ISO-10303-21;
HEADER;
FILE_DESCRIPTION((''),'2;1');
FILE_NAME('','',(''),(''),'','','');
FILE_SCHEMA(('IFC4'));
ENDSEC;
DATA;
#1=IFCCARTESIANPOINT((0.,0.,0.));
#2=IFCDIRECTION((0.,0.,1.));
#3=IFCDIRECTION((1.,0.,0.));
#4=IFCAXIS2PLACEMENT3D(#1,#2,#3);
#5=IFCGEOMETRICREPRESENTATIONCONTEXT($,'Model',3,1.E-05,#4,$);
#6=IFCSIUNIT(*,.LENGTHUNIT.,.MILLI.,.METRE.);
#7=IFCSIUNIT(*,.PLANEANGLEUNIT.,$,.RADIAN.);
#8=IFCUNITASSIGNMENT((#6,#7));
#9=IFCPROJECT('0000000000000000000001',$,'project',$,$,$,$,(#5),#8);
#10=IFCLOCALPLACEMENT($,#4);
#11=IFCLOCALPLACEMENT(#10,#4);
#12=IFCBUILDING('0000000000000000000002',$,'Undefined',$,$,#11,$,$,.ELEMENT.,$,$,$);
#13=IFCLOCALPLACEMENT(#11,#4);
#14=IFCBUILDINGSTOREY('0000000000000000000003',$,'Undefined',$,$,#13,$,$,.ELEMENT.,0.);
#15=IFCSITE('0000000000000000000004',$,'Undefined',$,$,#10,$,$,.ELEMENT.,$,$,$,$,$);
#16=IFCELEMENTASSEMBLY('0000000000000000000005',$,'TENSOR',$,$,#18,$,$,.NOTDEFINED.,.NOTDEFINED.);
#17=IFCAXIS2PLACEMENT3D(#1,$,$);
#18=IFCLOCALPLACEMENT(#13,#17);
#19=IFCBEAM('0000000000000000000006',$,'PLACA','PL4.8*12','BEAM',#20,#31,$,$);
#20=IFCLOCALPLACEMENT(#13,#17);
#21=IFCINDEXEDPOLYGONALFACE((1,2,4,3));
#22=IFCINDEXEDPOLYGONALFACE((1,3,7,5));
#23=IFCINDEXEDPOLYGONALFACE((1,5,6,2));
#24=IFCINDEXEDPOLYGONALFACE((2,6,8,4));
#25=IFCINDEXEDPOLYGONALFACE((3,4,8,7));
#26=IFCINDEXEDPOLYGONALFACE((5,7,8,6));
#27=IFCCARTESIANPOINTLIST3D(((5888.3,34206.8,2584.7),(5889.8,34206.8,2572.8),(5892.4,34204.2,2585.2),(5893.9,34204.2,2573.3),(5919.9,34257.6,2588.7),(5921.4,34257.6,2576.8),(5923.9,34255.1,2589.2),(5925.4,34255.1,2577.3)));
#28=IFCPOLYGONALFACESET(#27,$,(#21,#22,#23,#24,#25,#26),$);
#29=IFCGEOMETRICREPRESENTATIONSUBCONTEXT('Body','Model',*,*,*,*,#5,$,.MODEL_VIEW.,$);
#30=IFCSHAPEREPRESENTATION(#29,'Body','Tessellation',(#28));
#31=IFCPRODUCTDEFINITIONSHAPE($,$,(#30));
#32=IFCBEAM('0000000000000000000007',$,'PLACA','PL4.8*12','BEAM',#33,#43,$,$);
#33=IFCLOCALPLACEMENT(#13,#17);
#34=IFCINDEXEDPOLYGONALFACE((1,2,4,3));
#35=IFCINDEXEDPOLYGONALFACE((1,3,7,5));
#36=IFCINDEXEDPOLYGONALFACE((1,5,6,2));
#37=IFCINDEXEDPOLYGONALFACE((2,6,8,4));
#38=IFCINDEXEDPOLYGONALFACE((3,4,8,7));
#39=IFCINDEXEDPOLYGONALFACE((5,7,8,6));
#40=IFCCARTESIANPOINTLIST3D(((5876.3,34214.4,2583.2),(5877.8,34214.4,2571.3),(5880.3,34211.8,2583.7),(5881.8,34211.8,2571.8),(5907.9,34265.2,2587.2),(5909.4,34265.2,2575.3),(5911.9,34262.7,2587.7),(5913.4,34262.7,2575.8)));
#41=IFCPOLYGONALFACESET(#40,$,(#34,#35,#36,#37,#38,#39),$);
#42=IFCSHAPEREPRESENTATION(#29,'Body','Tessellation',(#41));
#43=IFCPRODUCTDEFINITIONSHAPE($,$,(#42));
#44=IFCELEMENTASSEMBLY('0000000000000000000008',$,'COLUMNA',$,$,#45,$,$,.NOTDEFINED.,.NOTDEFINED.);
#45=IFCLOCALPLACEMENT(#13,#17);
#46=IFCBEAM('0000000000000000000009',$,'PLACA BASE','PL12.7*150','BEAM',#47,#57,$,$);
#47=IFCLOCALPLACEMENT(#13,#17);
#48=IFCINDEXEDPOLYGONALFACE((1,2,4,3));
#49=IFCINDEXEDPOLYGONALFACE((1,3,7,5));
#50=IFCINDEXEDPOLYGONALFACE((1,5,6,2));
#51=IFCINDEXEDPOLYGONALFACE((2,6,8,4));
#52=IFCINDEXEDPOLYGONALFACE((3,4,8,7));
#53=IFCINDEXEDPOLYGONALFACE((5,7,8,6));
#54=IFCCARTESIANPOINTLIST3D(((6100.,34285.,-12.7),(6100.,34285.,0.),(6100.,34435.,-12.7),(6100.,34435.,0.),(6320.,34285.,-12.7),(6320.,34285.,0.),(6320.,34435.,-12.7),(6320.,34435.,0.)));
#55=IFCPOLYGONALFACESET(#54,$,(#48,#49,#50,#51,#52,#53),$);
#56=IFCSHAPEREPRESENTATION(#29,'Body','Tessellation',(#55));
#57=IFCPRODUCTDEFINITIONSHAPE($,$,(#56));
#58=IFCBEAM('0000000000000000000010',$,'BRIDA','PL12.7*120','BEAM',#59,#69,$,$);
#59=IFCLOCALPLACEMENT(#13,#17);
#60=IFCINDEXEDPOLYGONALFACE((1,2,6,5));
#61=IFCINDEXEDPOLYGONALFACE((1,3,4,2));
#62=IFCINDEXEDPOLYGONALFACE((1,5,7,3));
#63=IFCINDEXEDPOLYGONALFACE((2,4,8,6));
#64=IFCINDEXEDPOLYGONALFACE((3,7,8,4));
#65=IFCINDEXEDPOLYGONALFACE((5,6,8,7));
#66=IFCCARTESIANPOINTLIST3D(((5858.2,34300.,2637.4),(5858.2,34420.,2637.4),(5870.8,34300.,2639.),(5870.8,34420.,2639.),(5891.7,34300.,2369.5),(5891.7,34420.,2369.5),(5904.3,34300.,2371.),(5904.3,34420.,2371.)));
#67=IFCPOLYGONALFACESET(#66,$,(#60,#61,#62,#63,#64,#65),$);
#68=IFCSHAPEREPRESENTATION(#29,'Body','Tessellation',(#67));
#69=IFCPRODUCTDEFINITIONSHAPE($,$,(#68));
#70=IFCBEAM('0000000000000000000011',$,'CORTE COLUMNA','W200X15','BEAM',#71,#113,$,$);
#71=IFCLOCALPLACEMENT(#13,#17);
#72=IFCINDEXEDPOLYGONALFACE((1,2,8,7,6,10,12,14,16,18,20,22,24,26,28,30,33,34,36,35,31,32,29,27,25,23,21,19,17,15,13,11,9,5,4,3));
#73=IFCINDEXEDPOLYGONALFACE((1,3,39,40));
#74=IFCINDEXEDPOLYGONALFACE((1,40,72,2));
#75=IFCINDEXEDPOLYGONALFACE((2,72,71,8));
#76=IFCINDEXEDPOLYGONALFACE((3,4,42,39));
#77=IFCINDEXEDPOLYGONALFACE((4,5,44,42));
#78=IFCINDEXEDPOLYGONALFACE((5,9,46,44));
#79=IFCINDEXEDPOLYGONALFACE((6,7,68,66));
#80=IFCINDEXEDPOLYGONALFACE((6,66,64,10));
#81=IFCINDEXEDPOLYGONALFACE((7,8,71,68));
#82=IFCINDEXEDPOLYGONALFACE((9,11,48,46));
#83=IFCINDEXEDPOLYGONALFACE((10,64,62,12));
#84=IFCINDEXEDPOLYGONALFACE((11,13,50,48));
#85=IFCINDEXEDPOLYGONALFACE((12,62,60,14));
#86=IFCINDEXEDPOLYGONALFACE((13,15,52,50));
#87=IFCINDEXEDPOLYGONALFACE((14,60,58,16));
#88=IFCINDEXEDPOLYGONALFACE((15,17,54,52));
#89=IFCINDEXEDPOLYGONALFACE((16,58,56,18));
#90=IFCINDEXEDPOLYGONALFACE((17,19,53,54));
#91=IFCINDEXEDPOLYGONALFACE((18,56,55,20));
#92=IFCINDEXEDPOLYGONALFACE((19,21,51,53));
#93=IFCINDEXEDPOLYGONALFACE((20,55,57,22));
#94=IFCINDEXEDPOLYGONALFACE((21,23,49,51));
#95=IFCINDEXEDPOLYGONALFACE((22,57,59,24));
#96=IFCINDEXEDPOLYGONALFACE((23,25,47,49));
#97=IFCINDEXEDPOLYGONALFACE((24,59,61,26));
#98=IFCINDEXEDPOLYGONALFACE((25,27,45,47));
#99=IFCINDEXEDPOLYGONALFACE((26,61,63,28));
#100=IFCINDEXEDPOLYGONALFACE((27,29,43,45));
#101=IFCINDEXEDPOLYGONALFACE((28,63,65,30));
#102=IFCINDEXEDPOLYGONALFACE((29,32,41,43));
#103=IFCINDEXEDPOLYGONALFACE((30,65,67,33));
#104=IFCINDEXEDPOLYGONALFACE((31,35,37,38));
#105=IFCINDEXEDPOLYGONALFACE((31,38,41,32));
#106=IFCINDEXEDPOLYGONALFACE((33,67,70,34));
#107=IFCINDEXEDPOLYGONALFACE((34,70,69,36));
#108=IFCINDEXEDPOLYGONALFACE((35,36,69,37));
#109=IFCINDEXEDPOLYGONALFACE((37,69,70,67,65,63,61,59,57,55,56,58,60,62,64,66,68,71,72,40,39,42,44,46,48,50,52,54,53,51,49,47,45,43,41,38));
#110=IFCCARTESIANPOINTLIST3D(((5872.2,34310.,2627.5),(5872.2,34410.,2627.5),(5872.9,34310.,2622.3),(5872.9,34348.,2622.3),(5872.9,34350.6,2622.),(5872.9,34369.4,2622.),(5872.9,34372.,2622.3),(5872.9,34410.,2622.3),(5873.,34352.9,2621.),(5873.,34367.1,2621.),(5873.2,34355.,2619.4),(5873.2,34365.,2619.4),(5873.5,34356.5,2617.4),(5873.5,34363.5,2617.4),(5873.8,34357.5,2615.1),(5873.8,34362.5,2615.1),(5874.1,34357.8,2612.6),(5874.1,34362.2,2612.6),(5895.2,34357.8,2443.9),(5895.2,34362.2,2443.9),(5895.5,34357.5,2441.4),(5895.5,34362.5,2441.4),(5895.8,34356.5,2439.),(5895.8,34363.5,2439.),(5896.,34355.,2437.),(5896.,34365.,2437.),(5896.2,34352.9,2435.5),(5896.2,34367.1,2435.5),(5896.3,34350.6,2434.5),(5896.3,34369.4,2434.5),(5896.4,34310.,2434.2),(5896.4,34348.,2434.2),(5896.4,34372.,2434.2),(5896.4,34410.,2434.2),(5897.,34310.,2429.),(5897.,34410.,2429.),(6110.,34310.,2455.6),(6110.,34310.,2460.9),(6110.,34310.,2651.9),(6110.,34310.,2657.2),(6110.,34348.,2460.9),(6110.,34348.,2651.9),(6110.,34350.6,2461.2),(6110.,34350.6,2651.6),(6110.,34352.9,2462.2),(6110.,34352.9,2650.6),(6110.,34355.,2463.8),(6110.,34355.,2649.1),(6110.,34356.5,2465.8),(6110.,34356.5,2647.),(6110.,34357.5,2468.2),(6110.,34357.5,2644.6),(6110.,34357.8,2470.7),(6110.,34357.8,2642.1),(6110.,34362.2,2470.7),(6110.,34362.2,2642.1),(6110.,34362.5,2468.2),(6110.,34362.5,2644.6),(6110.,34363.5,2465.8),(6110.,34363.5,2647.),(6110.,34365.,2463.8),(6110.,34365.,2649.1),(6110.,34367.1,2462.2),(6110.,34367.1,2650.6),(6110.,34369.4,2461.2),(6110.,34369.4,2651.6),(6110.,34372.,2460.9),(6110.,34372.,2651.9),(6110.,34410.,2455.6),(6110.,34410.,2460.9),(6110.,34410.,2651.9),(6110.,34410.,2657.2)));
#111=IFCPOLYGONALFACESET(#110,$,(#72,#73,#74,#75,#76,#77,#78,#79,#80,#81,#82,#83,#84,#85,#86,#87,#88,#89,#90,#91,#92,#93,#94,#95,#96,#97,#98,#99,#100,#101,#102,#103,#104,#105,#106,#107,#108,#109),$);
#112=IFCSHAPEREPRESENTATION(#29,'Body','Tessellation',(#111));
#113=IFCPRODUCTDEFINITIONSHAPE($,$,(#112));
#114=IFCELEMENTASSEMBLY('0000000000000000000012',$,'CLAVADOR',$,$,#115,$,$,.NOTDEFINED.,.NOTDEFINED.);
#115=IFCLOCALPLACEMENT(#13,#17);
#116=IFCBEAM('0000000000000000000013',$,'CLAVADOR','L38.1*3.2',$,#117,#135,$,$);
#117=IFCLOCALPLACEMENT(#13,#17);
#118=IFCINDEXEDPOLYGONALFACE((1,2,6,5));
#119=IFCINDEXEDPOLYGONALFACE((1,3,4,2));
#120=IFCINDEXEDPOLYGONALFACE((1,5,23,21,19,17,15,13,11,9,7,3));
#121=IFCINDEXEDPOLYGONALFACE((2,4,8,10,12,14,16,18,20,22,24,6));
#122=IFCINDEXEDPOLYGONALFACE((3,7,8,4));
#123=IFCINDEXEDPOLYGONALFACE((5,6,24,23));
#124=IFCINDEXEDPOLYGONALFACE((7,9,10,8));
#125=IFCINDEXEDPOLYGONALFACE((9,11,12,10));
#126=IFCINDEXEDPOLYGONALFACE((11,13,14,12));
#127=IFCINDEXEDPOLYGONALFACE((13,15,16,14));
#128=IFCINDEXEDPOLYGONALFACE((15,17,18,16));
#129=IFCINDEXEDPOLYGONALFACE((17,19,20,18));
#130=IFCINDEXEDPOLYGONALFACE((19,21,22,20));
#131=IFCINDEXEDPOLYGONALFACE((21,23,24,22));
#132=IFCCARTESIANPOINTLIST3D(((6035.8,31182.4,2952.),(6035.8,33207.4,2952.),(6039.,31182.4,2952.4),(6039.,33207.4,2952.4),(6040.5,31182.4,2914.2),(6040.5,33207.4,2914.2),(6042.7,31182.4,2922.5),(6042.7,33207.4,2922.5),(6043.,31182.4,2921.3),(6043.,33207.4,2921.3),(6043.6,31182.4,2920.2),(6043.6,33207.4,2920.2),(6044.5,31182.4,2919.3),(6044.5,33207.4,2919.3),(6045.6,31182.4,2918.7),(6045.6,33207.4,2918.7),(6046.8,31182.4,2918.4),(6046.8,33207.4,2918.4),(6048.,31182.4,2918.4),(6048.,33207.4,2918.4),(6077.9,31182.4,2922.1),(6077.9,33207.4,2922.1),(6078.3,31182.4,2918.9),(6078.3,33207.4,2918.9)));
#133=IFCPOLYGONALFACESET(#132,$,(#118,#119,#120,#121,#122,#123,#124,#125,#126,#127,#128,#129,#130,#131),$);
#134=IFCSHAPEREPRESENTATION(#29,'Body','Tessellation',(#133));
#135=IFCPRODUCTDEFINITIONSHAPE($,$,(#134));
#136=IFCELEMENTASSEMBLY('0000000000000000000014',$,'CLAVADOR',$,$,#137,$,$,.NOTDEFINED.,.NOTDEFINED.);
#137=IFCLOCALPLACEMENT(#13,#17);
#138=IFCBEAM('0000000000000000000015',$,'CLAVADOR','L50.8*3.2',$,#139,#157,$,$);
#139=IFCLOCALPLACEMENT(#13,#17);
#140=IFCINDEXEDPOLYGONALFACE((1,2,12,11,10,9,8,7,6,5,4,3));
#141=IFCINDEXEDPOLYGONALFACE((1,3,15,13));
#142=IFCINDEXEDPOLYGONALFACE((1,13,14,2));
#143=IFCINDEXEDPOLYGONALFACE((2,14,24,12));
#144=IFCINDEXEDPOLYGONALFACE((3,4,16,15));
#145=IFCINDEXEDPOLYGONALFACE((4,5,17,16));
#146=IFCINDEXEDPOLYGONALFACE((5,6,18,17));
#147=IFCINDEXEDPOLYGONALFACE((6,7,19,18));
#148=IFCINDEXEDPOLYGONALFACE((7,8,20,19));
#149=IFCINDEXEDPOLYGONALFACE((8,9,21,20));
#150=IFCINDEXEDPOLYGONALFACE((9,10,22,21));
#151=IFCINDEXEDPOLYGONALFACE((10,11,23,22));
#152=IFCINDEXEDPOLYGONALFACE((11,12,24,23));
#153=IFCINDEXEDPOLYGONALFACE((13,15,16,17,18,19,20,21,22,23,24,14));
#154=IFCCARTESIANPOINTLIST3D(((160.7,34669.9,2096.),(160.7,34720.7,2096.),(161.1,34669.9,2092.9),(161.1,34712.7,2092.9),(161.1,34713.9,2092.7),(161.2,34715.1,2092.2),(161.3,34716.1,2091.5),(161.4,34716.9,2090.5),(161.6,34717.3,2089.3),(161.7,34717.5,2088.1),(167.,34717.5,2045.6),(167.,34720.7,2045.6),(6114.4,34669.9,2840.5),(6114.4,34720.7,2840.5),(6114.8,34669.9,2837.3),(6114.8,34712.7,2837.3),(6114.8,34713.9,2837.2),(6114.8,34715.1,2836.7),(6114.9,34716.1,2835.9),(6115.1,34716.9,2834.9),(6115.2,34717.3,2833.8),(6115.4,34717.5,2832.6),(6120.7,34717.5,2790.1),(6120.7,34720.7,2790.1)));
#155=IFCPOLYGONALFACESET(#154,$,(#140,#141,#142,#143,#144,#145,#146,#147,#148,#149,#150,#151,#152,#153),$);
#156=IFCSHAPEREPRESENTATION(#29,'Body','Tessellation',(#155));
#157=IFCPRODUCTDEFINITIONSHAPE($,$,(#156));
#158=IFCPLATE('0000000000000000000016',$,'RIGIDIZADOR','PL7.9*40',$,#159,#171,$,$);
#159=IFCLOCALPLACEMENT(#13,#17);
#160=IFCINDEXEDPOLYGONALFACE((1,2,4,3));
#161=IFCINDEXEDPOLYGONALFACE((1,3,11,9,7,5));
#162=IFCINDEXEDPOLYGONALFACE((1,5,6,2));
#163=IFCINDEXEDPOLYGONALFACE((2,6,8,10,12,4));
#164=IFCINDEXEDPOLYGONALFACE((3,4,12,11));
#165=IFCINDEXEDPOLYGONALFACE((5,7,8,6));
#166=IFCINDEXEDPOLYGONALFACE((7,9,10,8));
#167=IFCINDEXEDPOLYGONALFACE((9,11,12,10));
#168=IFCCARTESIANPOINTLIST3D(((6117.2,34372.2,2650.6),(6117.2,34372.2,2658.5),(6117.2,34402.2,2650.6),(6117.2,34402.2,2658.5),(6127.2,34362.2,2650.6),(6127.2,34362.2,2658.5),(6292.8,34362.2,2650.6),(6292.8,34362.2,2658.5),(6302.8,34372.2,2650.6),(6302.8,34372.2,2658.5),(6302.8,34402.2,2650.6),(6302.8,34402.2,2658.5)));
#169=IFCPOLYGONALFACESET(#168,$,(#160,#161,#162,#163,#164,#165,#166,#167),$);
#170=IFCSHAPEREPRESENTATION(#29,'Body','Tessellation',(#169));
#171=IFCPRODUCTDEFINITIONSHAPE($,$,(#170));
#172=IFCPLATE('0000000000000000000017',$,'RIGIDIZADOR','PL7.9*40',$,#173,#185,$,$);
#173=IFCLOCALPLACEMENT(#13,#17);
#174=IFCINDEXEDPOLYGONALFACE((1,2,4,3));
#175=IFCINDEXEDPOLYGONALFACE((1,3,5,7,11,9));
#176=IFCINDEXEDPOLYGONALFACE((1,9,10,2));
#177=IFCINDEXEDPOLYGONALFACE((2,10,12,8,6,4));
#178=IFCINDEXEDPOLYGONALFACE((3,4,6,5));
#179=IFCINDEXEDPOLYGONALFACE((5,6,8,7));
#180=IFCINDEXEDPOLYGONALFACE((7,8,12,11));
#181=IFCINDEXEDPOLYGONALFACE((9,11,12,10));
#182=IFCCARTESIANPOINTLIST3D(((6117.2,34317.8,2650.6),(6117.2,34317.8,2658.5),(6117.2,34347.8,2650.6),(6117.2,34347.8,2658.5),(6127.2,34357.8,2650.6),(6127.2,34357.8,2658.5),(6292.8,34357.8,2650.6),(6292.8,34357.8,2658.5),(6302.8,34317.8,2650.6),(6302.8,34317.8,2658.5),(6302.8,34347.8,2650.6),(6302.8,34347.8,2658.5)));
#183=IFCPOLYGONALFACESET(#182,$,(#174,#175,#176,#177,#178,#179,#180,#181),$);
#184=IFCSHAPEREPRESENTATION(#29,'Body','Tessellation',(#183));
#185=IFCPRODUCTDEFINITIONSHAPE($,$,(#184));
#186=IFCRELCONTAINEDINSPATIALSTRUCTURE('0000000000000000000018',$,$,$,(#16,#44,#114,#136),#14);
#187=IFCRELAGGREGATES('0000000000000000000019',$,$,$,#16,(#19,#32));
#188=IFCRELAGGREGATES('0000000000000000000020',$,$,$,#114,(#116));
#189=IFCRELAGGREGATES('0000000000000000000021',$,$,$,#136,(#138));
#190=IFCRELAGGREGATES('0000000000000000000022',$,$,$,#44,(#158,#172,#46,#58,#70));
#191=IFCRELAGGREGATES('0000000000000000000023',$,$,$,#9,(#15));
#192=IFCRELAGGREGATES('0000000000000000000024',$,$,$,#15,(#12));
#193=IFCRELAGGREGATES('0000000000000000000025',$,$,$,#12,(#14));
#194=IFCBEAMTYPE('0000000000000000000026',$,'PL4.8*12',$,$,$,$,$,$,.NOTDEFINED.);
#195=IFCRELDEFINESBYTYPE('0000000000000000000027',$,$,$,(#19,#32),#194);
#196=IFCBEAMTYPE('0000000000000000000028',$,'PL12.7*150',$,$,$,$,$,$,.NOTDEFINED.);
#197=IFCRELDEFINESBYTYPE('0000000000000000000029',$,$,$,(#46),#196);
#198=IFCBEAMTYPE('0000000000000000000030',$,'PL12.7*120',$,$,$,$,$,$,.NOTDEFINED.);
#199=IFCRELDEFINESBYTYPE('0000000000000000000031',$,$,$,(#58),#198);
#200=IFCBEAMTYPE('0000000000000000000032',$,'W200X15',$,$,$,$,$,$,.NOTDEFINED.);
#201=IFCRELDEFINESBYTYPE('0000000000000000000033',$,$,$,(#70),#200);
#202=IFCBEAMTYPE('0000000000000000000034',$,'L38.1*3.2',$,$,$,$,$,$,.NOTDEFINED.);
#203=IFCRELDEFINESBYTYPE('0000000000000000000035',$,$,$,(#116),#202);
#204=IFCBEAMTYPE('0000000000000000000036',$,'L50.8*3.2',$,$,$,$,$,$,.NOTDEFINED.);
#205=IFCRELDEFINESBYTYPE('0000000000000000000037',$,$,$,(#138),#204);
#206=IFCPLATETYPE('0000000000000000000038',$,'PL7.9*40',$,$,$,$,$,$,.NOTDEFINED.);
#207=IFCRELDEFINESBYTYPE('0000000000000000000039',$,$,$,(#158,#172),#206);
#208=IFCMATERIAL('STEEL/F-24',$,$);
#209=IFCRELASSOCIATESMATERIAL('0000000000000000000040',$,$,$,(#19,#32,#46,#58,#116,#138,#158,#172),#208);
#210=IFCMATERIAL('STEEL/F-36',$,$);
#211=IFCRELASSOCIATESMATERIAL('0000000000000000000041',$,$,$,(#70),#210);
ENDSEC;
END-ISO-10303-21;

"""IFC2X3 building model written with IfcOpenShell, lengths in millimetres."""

from ifc_helpers import new_model, si_unit, frame, origin_with_axes, origin_2d_with_axis, place, context, subcontext, project, spatial, polyline, rectangle, i_section, l_section, outline, extrude, clip, halfspace, material, type_object, element, aggregate, save


model = new_model("IFC2X3")

# Units and contexts
model_context = context("Model", 3, precision=1e-05, world=origin_with_axes())
body_context = subcontext(model_context, "Body", "Model", "MODEL_VIEW")
ifc_project = project(units=[si_unit("LENGTHUNIT", "METRE", prefix="MILLI"), si_unit("PLANEANGLEUNIT", "RADIAN")], contexts=[model_context])

# Site, building, storey
site_placement = place(None, origin_with_axes())
site = spatial("IfcSite", under=ifc_project, at=site_placement, Name="Undefined", CompositionType="ELEMENT")
building_placement = place(site_placement, origin_with_axes())
building = spatial("IfcBuilding", under=site, at=building_placement, Name="Undefined", CompositionType="ELEMENT")
storey_placement = place(building_placement, origin_with_axes())
storey = spatial("IfcBuildingStorey", under=building, at=storey_placement, Name="Undefined", CompositionType="ELEMENT", Elevation=0.0)

# Element assemblies, beams
assembly_1_placement = place(storey_placement, origin_with_axes())
assembly_1 = element("IfcElementAssembly", 1, at=assembly_1_placement, inside=storey, Name="TENSOR", AssemblyPlace="NOTDEFINED", PredefinedType="NOTDEFINED")
ifc_material_1 = material(Name="STEEL/F-24")
beam_type_1 = type_object("IfcBeamType", Name="PL4.8*12", PredefinedType="NOTDEFINED")
beam_1_placement = place(assembly_1_placement, frame((5922.7, 34256.4, 2583.0), z_axis=(0.124075, 0.0, -0.992273), x_axis=(-0.526076, -0.84789, -0.065781)))
beam_1 = element("IfcBeam", 2, at=beam_1_placement, type_object=beam_type_1, material=ifc_material_1, Name="PLACA", Description="PL4.8*12", ObjectType="BEAM", context=body_context, shape_type="SweptSolid", body=[
    extrude(rectangle(XDim=4.8, YDim=12.0, at=origin_2d_with_axis()), frame((60.0, 0.0, 0.0), z_axis=(-1.0, 0.0, 0.0), x_axis=(0.0, -1.0, 0.0)), (0.0, 0.0, 1.0), 60.0),
])
beam_2_placement = place(assembly_1_placement, frame((5910.6, 34264.0, 2581.5), z_axis=(0.124075, 0.0, -0.992273), x_axis=(-0.526076, -0.84789, -0.065781)))
beam_2 = element("IfcBeam", 3, at=beam_2_placement, type_object=beam_type_1, material=ifc_material_1, Name="PLACA", Description="PL4.8*12", ObjectType="BEAM", context=body_context, shape_type="SweptSolid", body=[
    extrude(rectangle(XDim=4.8, YDim=12.0, at=origin_2d_with_axis()), frame((60.0, 0.0, 0.0), z_axis=(-1.0, 0.0, 0.0), x_axis=(0.0, -1.0, 0.0)), (0.0, 0.0, 1.0), 60.0),
])
aggregate(assembly_1, [beam_1, beam_2])
assembly_2_placement = place(storey_placement, origin_with_axes())
assembly_2 = element("IfcElementAssembly", 4, at=assembly_2_placement, inside=storey, Name="COLUMNA", AssemblyPlace="NOTDEFINED", PredefinedType="NOTDEFINED")
beam_type_2 = type_object("IfcBeamType", Name="PL12.7*150", PredefinedType="NOTDEFINED")
beam_3_placement = place(assembly_2_placement, frame((6100.0, 34360.0, -6.4), z_axis=(0.0, -1.0, 0.0), x_axis=(1.0, 0.0, 0.0)))
beam_3 = element("IfcBeam", 5, at=beam_3_placement, type_object=beam_type_2, material=ifc_material_1, Name="PLACA BASE", Description="PL12.7*150", ObjectType="BEAM", context=body_context, shape_type="SweptSolid", body=[
    extrude(rectangle(XDim=12.7, YDim=150.0, at=origin_2d_with_axis()), frame((220.0, 0.0, 0.0), z_axis=(-1.0, 0.0, 0.0), x_axis=(0.0, -1.0, 0.0)), (0.0, 0.0, 1.0), 220.0),
])
beam_type_3 = type_object("IfcBeamType", Name="PL12.7*120", PredefinedType="NOTDEFINED")
beam_4_placement = place(assembly_2_placement, frame((5864.5, 34360.0, 2638.2), z_axis=(0.0, 1.0, 0.0), x_axis=(0.124077, 0.0, -0.992273)))
beam_4 = element("IfcBeam", 6, at=beam_4_placement, type_object=beam_type_3, material=ifc_material_1, Name="BRIDA", Description="PL12.7*120", ObjectType="BEAM", context=body_context, shape_type="SweptSolid", body=[
    extrude(rectangle(XDim=12.7, YDim=120.0, at=origin_2d_with_axis()), frame((270.0, 0.0, 0.0), z_axis=(-1.0, 0.0, 0.0), x_axis=(0.0, -1.0, 0.0)), (0.0, 0.0, 1.0), 270.0),
])
ifc_material_2 = material(Name="STEEL/F-36")
beam_type_4 = type_object("IfcBeamType", Name="W200X15", PredefinedType="NOTDEFINED")
beam_5_placement = place(assembly_2_placement, frame((5872.0, 34360.0, 2526.7), z_axis=(-0.124075, 0.0, 0.992273), x_axis=(0.992273, 0.0, 0.124075)))
beam_5 = element("IfcBeam", 7, at=beam_5_placement, type_object=beam_type_4, material=ifc_material_2, Name="CORTE COLUMNA", Description="W200X15", ObjectType="BEAM", context=body_context, shape_type="Clipping", body=[
    clip(clip(extrude(i_section(OverallWidth=100.0, OverallDepth=200.0, WebThickness=4.3, FlangeThickness=5.2, FilletRadius=9.8, at=origin_2d_with_axis()), frame((277.3, 0.0, 0.0), z_axis=(-1.0, 0.0, 0.0), x_axis=(0.0, -1.0, 0.0)), (0.0, 0.0, 1.0), 302.1), halfspace(frame((239.8, 0.0, 0.0), z_axis=(-0.992273, 0.0, 0.124075), x_axis=(0.0, 1.0, 0.0)), True)), halfspace(frame((12.7, 0.0, 0.0), z_axis=(1.0, 0.0, 0.000002), x_axis=(0.0, -1.0, 0.0)), True)),
])

# Element assemblies, beams
assembly_3_placement = place(storey_placement, origin_with_axes())
assembly_3 = element("IfcElementAssembly", 8, at=assembly_3_placement, inside=storey, Name="CLAVADOR", AssemblyPlace="NOTDEFINED", PredefinedType="NOTDEFINED")
beam_type_5 = type_object("IfcBeamType", Name="L38.1*3.2", PredefinedType="NOTDEFINED")
beam_6_placement = place(assembly_3_placement, frame((6057.0, 33207.4, 2935.5), z_axis=(0.992273, 0.0, 0.124075), x_axis=(0.0, -1.0, 0.0)))
beam_6 = element("IfcBeam", 9, at=beam_6_placement, type_object=beam_type_5, material=ifc_material_1, Name="CLAVADOR", Description="L38.1*3.2", context=body_context, shape_type="SweptSolid", body=[
    extrude(l_section(Depth=38.1, Width=38.1, Thickness=3.2, FilletRadius=4.8, at=origin_2d_with_axis()), frame((2025.0, 0.0, 0.0), z_axis=(-1.0, 0.0, 0.0), x_axis=(0.0, -1.0, 0.0)), (0.0, 0.0, 1.0), 2025.0),
])
aggregate(assembly_3, [beam_6])
assembly_4_placement = place(storey_placement, origin_with_axes())
assembly_4 = element("IfcElementAssembly", 10, at=assembly_4_placement, inside=storey, Name="CLAVADOR", AssemblyPlace="NOTDEFINED", PredefinedType="NOTDEFINED")
beam_type_6 = type_object("IfcBeamType", Name="L50.8*3.2", PredefinedType="NOTDEFINED")
beam_7_placement = place(assembly_4_placement, frame((6117.5, 34695.3, 2815.3), z_axis=(0.124075, 0.0, -0.992273), x_axis=(-0.992273, 0.0, -0.124075)))
beam_7 = element("IfcBeam", 11, at=beam_7_placement, type_object=beam_type_6, material=ifc_material_1, Name="CLAVADOR", Description="L50.8*3.2", context=body_context, shape_type="SweptSolid", body=[
    extrude(l_section(Depth=50.8, Width=50.8, Thickness=3.2, FilletRadius=4.8, at=origin_2d_with_axis()), frame((6000.0, 0.0, 0.0), z_axis=(-1.0, 0.0, 0.0), x_axis=(0.0, -1.0, 0.0)), (0.0, 0.0, 1.0), 6000.0),
])
aggregate(assembly_4, [beam_7])

# Plates
plate_type_1 = type_object("IfcPlateType", Name="PL7.9*40", PredefinedType="NOTDEFINED")
plate_1_placement = place(assembly_2_placement, frame((6117.2, 34402.2, 2654.6), z_axis=(0.0, 0.0, 1.0), x_axis=(0.0, -1.0, 0.0)))
plate_1 = element("IfcPlate", 12, at=plate_1_placement, type_object=plate_type_1, material=ifc_material_1, Name="RIGIDIZADOR", Description="PL7.9*40", context=body_context, shape_type="SweptSolid", body=[
    extrude(outline(polyline([(0.0, 0.0), (30.0, 0.0), (40.0, 10.0), (40.0, 175.6), (30.0, 185.6), (0.0, 185.6), (0.0, 0.0)])), frame((0.0, 0.0, -4.0), z_axis=(0.0, 0.0, 1.0), x_axis=(1.0, 0.0, 0.0)), (0.0, 0.0, 1.0), 7.9),
])
plate_2_placement = place(assembly_2_placement, frame((6117.2, 34357.8, 2654.6), z_axis=(0.0, 0.0, 1.0), x_axis=(0.0, -1.0, 0.0)))
plate_2 = element("IfcPlate", 13, at=plate_2_placement, type_object=plate_type_1, material=ifc_material_1, Name="RIGIDIZADOR", Description="PL7.9*40", context=body_context, shape_type="SweptSolid", body=[
    extrude(outline(polyline([(0.0, 10.0), (10.0, 0.0), (40.0, 0.0), (40.0, 185.6), (10.0, 185.6), (0.0, 175.6), (0.0, 10.0)])), frame((0.0, 0.0, -4.0), z_axis=(0.0, 0.0, 1.0), x_axis=(1.0, 0.0, 0.0)), (0.0, 0.0, 1.0), 7.9),
])

aggregate(assembly_2, [plate_1, plate_2, beam_3, beam_4, beam_5])

save(model, "model.ifc")
